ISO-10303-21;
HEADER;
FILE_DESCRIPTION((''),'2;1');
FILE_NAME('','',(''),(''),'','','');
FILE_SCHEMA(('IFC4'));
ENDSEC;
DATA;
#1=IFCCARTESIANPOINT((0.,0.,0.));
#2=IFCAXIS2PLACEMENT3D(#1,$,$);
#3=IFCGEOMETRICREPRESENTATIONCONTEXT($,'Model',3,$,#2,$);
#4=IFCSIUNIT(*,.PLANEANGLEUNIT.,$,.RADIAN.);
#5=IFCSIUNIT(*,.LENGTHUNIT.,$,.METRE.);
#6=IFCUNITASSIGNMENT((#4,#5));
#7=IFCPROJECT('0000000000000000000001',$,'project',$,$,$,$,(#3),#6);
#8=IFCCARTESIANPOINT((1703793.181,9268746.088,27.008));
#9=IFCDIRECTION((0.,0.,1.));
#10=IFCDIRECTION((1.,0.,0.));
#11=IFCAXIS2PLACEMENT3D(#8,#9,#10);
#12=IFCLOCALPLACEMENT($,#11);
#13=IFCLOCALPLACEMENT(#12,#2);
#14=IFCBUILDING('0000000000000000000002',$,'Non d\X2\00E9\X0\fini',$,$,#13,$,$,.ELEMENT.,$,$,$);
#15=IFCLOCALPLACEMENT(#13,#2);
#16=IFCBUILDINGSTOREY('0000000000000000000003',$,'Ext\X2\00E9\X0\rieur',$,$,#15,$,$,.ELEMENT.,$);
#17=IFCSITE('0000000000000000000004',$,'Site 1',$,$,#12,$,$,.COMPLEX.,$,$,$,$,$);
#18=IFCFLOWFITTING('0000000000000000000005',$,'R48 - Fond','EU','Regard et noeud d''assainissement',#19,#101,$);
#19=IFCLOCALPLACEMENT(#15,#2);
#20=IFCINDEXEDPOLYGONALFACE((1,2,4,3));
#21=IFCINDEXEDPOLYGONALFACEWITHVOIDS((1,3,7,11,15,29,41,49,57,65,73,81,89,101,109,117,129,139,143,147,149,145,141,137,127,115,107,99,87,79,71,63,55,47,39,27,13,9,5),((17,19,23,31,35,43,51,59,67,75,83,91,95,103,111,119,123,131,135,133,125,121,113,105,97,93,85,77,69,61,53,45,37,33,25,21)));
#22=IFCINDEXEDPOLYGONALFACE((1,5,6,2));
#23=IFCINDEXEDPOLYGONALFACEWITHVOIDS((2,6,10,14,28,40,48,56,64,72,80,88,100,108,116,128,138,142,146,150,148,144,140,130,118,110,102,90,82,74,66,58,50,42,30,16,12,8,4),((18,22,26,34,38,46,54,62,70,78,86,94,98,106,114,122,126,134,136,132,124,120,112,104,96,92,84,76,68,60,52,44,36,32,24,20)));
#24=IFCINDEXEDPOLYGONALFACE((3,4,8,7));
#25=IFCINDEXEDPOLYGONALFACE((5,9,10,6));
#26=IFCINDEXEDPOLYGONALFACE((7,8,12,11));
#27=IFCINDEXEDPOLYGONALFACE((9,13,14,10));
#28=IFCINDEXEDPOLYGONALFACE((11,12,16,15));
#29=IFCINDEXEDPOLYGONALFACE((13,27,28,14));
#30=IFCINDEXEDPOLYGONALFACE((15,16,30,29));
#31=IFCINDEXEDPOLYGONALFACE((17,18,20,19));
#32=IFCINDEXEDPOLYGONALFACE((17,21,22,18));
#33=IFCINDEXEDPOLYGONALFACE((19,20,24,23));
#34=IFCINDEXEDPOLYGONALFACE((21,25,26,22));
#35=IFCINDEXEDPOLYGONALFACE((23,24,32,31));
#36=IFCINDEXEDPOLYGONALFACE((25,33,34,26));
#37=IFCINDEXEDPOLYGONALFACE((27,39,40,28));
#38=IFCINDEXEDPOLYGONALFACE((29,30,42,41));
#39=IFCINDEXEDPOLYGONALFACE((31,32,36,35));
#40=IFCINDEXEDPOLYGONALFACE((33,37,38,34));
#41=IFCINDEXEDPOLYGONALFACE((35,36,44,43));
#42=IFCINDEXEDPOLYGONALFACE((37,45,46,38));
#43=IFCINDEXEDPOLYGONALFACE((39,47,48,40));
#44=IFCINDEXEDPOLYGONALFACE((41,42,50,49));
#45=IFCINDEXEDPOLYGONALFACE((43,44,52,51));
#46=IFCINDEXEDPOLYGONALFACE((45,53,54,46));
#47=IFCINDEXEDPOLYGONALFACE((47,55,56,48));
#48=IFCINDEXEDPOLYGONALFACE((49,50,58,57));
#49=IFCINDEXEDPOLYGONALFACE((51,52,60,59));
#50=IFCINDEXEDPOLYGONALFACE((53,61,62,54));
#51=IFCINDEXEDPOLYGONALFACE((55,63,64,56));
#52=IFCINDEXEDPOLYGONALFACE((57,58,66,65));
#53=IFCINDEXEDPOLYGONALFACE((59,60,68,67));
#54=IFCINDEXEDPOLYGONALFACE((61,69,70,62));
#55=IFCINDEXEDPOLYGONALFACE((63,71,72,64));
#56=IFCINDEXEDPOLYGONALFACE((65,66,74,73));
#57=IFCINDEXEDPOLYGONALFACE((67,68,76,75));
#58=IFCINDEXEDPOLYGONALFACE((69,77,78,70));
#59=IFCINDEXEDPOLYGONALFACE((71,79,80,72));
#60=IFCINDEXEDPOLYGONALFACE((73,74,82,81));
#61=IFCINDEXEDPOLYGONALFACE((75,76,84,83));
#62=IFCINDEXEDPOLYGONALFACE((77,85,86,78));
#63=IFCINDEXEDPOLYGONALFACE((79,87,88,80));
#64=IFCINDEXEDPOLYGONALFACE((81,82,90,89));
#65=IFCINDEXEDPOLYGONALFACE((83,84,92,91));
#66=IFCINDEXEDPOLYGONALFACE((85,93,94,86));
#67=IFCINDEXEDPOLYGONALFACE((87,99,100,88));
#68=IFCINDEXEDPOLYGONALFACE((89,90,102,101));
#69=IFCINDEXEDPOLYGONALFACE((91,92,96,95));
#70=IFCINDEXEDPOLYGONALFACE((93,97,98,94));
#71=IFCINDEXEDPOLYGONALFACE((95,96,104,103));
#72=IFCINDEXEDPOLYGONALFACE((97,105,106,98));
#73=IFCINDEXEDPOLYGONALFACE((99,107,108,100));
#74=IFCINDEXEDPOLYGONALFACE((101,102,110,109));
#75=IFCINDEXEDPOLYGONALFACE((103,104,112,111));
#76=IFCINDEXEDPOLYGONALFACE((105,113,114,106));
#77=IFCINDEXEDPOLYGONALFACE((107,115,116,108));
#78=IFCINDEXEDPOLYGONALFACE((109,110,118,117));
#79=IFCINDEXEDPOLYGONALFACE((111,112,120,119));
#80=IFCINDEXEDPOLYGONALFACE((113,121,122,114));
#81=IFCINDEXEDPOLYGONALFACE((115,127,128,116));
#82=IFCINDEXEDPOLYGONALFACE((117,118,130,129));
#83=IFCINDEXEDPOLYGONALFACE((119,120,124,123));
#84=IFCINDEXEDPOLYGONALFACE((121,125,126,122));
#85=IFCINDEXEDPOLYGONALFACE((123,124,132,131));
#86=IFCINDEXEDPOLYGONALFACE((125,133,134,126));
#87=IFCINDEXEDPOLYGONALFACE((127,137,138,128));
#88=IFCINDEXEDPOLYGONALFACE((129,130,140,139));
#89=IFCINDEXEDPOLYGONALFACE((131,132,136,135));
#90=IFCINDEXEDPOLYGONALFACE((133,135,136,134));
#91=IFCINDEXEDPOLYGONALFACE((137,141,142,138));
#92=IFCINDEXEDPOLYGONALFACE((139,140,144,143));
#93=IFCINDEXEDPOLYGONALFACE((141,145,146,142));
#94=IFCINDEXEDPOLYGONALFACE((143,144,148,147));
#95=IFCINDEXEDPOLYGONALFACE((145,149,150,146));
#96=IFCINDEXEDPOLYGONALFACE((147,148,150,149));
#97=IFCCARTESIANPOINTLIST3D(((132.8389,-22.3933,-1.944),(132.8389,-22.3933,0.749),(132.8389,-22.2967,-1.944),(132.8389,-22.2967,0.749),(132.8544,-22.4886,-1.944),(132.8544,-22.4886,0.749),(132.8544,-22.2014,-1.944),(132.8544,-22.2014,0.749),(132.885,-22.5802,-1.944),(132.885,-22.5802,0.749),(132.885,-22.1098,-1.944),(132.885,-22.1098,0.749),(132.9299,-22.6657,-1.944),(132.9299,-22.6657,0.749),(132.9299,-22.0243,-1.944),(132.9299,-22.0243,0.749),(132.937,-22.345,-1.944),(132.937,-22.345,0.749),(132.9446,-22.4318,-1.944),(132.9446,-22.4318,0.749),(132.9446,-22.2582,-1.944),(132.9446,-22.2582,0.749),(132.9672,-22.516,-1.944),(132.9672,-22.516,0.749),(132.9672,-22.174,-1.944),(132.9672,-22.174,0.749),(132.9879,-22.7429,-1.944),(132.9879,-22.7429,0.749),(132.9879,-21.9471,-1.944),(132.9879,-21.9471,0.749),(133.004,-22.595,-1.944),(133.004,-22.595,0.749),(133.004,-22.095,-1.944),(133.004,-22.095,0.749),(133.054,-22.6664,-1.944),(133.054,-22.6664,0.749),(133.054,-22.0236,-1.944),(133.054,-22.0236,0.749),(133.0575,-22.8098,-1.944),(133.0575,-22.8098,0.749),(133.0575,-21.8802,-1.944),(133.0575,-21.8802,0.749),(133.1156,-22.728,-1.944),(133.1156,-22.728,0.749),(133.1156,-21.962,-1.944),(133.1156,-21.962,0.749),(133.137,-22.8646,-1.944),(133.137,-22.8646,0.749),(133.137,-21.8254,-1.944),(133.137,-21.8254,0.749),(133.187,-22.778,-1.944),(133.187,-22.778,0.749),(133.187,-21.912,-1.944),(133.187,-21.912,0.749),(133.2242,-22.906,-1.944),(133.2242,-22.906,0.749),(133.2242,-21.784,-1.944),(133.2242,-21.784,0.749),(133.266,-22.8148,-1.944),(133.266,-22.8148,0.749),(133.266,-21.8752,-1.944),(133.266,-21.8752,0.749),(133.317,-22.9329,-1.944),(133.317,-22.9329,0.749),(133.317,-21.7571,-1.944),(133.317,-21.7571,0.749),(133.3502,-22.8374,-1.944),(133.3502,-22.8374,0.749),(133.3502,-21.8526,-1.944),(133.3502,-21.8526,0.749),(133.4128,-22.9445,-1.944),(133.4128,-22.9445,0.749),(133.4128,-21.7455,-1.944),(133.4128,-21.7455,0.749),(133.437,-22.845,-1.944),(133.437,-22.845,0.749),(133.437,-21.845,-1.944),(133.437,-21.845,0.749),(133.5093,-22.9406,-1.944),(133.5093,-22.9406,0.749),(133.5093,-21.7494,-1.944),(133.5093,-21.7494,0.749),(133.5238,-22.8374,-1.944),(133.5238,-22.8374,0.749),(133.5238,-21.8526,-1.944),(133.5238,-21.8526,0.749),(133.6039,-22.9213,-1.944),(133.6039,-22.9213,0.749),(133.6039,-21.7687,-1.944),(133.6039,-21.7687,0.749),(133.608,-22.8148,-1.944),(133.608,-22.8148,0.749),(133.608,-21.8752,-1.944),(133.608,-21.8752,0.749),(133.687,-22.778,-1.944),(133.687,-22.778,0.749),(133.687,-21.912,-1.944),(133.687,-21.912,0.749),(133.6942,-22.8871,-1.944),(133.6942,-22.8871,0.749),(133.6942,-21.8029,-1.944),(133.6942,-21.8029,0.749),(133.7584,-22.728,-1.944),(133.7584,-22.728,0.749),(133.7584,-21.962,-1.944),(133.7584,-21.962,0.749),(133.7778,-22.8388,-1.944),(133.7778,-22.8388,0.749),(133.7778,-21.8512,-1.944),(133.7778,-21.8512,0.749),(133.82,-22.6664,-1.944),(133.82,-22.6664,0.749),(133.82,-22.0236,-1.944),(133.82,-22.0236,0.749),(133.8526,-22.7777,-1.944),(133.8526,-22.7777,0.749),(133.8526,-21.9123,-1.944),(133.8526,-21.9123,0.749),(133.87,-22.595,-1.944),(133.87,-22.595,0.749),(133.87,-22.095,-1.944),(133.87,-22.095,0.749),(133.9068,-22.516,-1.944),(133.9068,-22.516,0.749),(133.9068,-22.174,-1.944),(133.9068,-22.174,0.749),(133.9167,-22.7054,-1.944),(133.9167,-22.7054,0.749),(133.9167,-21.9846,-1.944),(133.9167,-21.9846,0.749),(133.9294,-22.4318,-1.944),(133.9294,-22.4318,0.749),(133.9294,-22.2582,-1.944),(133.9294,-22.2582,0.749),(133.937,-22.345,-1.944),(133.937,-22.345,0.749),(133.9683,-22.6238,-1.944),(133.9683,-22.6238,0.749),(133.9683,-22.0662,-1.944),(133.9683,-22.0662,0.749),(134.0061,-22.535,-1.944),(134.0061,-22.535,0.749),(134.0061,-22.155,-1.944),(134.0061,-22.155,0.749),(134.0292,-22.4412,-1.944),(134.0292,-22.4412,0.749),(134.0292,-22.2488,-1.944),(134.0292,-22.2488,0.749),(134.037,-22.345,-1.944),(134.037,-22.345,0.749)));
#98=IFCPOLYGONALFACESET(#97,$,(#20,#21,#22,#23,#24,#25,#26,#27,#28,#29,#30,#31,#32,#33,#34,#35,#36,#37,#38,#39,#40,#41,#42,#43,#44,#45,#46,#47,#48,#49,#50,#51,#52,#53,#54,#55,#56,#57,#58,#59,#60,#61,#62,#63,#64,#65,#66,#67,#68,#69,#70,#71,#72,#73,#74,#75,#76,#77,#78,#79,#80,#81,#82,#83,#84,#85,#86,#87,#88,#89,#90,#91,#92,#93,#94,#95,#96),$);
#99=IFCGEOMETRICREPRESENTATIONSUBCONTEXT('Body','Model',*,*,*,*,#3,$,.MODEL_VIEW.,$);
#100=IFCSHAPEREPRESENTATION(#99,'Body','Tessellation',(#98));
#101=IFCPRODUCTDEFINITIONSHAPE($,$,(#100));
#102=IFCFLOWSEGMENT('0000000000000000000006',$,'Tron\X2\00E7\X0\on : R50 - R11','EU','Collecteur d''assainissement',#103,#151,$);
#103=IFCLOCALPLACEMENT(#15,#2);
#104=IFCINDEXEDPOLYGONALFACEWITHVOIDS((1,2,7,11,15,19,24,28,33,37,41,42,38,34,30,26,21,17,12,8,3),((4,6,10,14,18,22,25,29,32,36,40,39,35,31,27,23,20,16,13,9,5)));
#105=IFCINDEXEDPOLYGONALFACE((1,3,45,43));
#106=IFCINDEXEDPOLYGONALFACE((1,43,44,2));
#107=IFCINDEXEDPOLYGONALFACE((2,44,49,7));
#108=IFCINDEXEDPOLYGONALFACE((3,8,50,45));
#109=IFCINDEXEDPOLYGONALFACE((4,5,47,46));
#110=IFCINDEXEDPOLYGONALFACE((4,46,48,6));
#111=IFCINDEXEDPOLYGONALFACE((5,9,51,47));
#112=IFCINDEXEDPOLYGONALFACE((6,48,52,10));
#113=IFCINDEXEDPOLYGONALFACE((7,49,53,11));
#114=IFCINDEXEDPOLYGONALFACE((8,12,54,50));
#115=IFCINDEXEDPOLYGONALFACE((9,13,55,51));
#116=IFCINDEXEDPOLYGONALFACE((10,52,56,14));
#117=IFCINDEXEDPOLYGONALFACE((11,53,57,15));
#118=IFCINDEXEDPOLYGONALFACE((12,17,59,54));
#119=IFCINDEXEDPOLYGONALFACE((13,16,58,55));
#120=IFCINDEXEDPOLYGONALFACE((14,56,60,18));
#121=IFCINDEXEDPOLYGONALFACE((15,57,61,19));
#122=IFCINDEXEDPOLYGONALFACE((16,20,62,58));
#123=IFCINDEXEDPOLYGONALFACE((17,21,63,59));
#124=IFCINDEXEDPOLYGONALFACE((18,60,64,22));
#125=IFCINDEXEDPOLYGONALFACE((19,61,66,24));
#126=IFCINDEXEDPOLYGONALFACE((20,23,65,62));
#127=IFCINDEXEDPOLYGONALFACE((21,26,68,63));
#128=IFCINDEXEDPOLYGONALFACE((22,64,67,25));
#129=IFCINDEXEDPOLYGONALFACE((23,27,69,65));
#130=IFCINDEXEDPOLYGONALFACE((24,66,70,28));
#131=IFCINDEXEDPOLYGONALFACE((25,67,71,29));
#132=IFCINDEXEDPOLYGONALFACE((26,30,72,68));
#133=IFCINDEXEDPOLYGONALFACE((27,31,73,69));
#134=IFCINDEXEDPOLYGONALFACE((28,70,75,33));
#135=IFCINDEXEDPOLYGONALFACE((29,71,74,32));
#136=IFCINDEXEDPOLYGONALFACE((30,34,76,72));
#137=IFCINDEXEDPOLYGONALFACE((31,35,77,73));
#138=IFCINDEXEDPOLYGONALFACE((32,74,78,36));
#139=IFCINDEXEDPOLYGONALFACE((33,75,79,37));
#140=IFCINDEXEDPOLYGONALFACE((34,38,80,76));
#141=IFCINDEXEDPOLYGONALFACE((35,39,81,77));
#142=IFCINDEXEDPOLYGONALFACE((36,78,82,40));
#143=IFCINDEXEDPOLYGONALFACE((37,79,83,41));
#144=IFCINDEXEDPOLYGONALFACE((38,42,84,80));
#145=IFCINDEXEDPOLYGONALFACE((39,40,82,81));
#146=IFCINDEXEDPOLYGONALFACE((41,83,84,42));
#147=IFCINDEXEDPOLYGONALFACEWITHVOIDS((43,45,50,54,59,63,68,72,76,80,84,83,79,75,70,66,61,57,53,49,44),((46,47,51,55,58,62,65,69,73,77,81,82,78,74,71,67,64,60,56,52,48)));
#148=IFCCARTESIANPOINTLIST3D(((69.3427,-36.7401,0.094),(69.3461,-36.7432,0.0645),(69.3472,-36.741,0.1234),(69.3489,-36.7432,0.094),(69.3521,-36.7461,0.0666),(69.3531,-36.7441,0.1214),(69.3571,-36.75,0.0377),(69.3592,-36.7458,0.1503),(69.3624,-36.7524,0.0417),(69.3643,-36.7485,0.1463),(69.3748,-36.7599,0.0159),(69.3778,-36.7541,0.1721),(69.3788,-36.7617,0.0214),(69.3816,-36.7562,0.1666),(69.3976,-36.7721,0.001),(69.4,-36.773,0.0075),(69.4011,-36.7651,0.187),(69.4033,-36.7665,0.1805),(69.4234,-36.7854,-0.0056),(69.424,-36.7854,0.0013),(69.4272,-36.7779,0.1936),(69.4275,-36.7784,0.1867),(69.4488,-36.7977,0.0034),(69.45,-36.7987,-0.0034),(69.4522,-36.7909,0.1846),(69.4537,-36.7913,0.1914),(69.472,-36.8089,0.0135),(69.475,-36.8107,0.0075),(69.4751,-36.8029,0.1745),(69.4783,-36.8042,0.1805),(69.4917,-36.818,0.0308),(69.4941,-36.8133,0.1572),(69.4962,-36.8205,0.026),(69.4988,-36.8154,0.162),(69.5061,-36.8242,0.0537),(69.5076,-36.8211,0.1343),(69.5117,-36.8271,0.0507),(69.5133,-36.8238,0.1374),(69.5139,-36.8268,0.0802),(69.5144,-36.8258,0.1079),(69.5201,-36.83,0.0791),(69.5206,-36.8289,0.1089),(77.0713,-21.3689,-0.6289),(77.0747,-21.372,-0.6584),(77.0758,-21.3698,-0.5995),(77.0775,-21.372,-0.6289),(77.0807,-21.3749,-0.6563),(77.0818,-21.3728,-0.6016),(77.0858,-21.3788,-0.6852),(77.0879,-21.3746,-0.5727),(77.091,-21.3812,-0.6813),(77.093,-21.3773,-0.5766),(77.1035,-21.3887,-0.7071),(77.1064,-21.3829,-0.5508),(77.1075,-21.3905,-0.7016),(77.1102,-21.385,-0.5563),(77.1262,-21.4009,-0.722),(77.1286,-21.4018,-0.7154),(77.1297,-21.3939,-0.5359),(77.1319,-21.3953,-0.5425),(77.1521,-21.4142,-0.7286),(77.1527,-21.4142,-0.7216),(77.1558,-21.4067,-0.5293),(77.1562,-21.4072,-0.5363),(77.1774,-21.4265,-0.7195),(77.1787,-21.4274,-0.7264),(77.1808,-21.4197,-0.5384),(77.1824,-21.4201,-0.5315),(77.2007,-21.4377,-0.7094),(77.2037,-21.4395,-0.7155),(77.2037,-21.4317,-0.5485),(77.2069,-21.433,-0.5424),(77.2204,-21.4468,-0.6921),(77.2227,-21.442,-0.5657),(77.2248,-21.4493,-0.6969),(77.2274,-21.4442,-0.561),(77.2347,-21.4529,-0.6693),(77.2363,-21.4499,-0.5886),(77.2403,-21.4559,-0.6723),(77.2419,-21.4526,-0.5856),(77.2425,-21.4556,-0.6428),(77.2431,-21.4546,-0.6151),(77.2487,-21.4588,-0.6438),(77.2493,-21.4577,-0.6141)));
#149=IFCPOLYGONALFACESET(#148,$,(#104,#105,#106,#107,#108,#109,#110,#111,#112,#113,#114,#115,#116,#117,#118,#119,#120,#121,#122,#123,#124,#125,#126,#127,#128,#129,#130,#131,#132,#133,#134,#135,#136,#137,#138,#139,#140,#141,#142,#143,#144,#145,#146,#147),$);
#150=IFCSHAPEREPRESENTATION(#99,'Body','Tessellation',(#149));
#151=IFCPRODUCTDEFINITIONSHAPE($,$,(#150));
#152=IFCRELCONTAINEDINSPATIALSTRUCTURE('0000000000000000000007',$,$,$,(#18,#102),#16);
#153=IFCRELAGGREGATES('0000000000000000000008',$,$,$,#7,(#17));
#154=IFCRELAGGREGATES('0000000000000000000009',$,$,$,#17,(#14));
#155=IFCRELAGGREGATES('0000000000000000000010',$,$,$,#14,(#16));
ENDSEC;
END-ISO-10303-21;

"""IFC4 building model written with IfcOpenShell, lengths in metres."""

from ifc_helpers import new_model, si_unit, frame, origin, origin_2d, place, context, subcontext, project, spatial, hollow_circle, extrude, element, save


model = new_model("IFC4")

# Units and contexts
model_context = context("Model", 3, world=origin())
body_context = subcontext(model_context, "Body", "Model", "MODEL_VIEW")
ifc_project = project(units=[si_unit("PLANEANGLEUNIT", "RADIAN"), si_unit("LENGTHUNIT", "METRE")], contexts=[model_context])

# Site, building, storey
site_placement = place(None, frame((1703793.181, 9268746.088, 27.008), z_axis=(0.0, 0.0, 1.0), x_axis=(1.0, 0.0, 0.0)))
site = spatial("IfcSite", under=ifc_project, at=site_placement, Name="Site 1", CompositionType="COMPLEX")
building_placement = place(site_placement, origin())
building = spatial("IfcBuilding", under=site, at=building_placement, Name="Non défini", CompositionType="ELEMENT")
storey_placement = place(building_placement, origin())
storey = spatial("IfcBuildingStorey", under=building, at=storey_placement, Name="Extérieur", CompositionType="ELEMENT")

# Flow fitting
flow_fitting_1_placement = place(storey_placement, origin())
element("IfcFlowFitting", 1, at=flow_fitting_1_placement, inside=storey, Name="R48 - Fond", Description="EU", ObjectType="Regard et noeud d'assainissement", context=body_context, shape_type="SweptSolid", body=[
    extrude(hollow_circle(Radius=0.6, WallThickness=0.1, at=origin_2d()), frame((133.437, -22.345, -1.944), z_axis=(0.0, 0.0, 1.0), x_axis=(1.0, 0.0, 0.0)), (0.0, 0.0, 1.0), 2.693),
])

# Flow segment
flow_segment_1_placement = place(storey_placement, origin())
element("IfcFlowSegment", 2, at=flow_segment_1_placement, inside=storey, Name="Tronçon : R50 - R11", Description="EU", ObjectType="Collecteur d'assainissement", context=body_context, shape_type="SweptSolid", body=[
    extrude(hollow_circle(Radius=0.1, WallThickness=0.007, at=origin_2d()), frame((69.432, -36.785, 0.094), z_axis=(0.449, 0.893, -0.042), x_axis=(-0.894, 0.449, 0.0)), (0.0, 0.0, 1.0), 17.22),
])

save(model, "model.ifc")
